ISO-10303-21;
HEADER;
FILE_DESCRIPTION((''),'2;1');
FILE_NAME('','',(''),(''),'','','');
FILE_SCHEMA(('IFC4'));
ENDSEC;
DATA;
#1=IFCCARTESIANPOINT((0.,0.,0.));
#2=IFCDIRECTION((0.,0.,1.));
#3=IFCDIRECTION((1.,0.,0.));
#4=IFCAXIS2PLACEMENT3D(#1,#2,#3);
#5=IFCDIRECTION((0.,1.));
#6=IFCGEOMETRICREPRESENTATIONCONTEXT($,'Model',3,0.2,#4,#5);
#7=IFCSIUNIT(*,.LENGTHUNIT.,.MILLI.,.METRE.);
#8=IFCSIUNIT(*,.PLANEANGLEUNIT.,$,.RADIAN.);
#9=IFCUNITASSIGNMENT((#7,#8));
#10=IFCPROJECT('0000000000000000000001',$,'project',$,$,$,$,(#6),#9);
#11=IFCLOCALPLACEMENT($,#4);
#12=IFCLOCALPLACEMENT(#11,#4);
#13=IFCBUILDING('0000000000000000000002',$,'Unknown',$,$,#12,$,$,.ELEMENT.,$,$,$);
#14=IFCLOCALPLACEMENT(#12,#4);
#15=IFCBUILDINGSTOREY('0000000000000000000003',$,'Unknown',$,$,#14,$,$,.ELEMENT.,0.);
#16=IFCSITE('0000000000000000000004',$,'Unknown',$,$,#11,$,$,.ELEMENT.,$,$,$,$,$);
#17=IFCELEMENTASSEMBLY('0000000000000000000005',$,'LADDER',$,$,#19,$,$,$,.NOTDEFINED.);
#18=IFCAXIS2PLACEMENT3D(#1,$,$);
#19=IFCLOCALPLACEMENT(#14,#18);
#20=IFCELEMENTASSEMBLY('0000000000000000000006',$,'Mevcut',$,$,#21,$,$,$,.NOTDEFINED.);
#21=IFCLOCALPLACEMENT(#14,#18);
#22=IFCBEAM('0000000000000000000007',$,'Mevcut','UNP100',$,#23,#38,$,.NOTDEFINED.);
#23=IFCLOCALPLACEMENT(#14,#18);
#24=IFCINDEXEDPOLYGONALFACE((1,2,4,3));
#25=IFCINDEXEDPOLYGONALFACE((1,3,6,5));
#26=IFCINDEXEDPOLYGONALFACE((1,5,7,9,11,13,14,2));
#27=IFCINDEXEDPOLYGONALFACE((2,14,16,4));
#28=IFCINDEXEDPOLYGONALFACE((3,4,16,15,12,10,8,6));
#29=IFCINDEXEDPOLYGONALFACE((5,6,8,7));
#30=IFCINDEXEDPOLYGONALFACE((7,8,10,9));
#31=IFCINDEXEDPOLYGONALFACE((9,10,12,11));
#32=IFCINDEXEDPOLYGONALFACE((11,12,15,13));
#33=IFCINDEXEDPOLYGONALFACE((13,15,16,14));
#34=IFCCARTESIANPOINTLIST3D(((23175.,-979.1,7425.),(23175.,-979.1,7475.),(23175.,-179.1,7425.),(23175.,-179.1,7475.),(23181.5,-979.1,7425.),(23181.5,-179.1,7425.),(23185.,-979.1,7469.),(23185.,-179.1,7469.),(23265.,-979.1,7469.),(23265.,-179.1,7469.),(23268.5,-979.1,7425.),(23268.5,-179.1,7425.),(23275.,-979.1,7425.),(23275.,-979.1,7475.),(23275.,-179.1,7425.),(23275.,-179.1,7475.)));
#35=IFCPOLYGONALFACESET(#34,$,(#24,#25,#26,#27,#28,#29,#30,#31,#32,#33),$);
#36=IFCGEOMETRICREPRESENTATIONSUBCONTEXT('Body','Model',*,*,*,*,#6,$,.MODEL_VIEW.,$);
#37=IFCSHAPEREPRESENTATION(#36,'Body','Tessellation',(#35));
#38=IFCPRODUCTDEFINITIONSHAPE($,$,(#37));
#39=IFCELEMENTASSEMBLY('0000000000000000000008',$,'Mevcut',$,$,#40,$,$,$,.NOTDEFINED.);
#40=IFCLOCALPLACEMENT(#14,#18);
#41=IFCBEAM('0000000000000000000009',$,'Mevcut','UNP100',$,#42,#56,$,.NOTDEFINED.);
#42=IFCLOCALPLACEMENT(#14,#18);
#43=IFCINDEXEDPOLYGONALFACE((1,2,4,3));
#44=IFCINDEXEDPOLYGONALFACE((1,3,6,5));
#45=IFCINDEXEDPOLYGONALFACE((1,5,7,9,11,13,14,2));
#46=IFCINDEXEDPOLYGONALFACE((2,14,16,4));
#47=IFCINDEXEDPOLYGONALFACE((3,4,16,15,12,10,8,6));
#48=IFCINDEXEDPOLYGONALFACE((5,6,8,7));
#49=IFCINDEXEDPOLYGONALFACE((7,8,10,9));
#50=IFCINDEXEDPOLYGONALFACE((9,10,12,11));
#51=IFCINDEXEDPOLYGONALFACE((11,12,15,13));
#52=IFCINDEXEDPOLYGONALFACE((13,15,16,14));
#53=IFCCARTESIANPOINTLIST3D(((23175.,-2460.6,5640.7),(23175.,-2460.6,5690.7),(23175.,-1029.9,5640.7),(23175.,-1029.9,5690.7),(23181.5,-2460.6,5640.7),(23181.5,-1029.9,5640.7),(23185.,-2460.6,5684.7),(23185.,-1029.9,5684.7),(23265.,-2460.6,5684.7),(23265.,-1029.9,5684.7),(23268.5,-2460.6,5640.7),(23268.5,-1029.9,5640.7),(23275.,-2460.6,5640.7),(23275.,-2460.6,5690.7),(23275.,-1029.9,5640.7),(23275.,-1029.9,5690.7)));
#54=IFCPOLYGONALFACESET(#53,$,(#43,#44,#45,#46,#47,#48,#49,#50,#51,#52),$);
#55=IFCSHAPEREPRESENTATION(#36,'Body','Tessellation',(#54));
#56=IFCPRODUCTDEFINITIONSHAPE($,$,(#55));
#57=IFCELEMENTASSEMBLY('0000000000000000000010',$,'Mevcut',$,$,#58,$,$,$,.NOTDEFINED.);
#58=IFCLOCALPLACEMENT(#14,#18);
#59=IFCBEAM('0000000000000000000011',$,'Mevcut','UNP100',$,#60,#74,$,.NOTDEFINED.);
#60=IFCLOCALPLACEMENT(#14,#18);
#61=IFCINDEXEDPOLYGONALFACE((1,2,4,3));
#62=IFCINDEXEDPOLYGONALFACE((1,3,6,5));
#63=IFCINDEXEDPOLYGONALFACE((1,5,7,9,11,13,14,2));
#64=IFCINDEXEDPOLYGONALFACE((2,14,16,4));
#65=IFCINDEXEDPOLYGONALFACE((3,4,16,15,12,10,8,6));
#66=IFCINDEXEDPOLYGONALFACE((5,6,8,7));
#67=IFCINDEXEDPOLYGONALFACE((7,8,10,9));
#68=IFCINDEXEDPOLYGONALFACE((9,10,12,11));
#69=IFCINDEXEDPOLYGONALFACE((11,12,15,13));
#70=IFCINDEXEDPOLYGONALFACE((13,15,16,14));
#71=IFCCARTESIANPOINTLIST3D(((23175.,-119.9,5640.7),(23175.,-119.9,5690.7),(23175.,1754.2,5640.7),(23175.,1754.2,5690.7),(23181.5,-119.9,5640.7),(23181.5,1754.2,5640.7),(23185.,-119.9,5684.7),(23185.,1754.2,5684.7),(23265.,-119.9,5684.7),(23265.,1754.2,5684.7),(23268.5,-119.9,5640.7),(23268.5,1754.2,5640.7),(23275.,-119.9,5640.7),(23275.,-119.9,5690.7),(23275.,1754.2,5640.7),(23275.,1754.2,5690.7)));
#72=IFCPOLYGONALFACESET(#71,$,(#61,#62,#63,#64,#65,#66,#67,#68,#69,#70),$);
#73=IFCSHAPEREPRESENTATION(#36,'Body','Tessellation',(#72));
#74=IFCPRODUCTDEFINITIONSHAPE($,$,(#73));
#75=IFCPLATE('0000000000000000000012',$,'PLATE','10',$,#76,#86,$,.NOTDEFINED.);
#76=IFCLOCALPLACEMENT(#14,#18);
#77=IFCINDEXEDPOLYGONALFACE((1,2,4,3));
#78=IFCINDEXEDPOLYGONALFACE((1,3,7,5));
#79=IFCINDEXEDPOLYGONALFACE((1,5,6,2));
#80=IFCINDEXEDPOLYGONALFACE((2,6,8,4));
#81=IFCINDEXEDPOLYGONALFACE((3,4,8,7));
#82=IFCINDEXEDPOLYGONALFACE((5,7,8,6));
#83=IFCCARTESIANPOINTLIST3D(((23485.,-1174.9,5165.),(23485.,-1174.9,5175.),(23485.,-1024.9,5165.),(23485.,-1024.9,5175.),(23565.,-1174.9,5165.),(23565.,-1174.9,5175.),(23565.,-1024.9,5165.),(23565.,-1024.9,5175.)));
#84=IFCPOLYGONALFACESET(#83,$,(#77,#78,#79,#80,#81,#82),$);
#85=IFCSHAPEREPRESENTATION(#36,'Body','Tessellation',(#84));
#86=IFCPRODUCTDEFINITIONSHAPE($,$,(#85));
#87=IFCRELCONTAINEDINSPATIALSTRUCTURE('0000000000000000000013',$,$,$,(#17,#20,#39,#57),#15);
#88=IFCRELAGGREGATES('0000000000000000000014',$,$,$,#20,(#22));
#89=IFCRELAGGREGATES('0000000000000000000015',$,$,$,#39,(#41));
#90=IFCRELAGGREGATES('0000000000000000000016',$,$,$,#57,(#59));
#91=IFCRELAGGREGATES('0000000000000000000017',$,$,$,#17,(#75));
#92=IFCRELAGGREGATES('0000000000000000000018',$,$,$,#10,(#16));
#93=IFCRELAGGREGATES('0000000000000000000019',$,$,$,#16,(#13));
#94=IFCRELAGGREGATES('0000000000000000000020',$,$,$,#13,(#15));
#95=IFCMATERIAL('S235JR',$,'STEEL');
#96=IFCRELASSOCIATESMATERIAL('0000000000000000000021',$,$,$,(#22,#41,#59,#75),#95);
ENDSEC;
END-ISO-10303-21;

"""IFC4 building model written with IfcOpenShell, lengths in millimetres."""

from ifc_helpers import new_model, si_unit, direction, frame, origin_with_axes, place, context, subcontext, project, spatial, line, indexed_curve, outline, extrude, material, element, aggregate, save


model = new_model("IFC4")

# Units and contexts
model_context = context("Model", 3, precision=0.2, world=origin_with_axes(), true_north=direction((0.0, 1.0)))
body_context = subcontext(model_context, "Body", "Model", "MODEL_VIEW")
ifc_project = project(units=[si_unit("LENGTHUNIT", "METRE", prefix="MILLI"), si_unit("PLANEANGLEUNIT", "RADIAN")], contexts=[model_context])

# Site, building, storey
site_placement = place(None, origin_with_axes())
site = spatial("IfcSite", under=ifc_project, at=site_placement, Name="Unknown", CompositionType="ELEMENT")
building_placement = place(site_placement, origin_with_axes())
building = spatial("IfcBuilding", under=site, at=building_placement, Name="Unknown", CompositionType="ELEMENT")
storey_placement = place(building_placement, origin_with_axes())
storey = spatial("IfcBuildingStorey", under=building, at=storey_placement, Name="Unknown", CompositionType="ELEMENT", Elevation=0.0)

# Element assembly
assembly_1_placement = place(storey_placement, frame((23525.0, -1699.9, 5175.0), z_axis=(0.0, 1.0, 0.0), x_axis=(0.0, 0.0, 1.0)))
assembly_1 = element("IfcElementAssembly", 1, at=assembly_1_placement, inside=storey, Name="LADDER", PredefinedType="NOTDEFINED")
ifc_material_1 = material(Name="S235JR", Category="STEEL")

# Element assemblies, beams
assembly_2_placement = place(storey_placement, frame((23225.0, -179.1, 7450.0), z_axis=(0.0, 0.0, -1.0), x_axis=(0.0, -1.0, 0.0)))
assembly_2 = element("IfcElementAssembly", 2, at=assembly_2_placement, inside=storey, Name="Mevcut", PredefinedType="NOTDEFINED")
beam_1_placement = place(assembly_2_placement, origin_with_axes())
beam_1 = element("IfcBeam", 3, at=beam_1_placement, material=ifc_material_1, Name="Mevcut", Description="UNP100", PredefinedType="NOTDEFINED", context=body_context, shape_type="SolidModel", body=[
    extrude(outline(indexed_curve([(-25.0, -50.0), (25.0, -50.0), (25.0, -43.5), (-19.0, -40.0), (-19.0, 40.0), (25.0, 43.5), (25.0, 50.0), (-25.0, 50.0)], segments=[line(1, 2, 3, 4, 5, 6, 7, 8, 1)])), frame((0.0, 0.0, 0.0), z_axis=(-1.0, 0.0, 0.0), x_axis=(0.0, 0.0, 1.0)), (0.0, 0.0, -1.0), 800.0),
])
aggregate(assembly_2, [beam_1])
assembly_3_placement = place(storey_placement, frame((23225.0, -1029.9, 5665.7), z_axis=(0.0, 0.0, -1.0), x_axis=(0.0, -1.0, 0.0)))
assembly_3 = element("IfcElementAssembly", 4, at=assembly_3_placement, inside=storey, Name="Mevcut", PredefinedType="NOTDEFINED")
beam_2_placement = place(assembly_3_placement, origin_with_axes())
beam_2 = element("IfcBeam", 5, at=beam_2_placement, material=ifc_material_1, Name="Mevcut", Description="UNP100", PredefinedType="NOTDEFINED", context=body_context, shape_type="SolidModel", body=[
    extrude(outline(indexed_curve([(-25.0, -50.0), (25.0, -50.0), (25.0, -43.5), (-19.0, -40.0), (-19.0, 40.0), (25.0, 43.5), (25.0, 50.0), (-25.0, 50.0)], segments=[line(1, 2, 3, 4, 5, 6, 7, 8, 1)])), frame((0.0, 0.0, 0.0), z_axis=(-1.0, 0.0, 0.0), x_axis=(0.0, 0.0, 1.0)), (0.0, 0.0, -1.0), 1430.7),
])
aggregate(assembly_3, [beam_2])
assembly_4_placement = place(storey_placement, frame((23225.0, 1754.2, 5665.7), z_axis=(0.0, 0.0, -1.0), x_axis=(0.0, -1.0, 0.0)))
assembly_4 = element("IfcElementAssembly", 6, at=assembly_4_placement, inside=storey, Name="Mevcut", PredefinedType="NOTDEFINED")
beam_3_placement = place(assembly_4_placement, origin_with_axes())
beam_3 = element("IfcBeam", 7, at=beam_3_placement, material=ifc_material_1, Name="Mevcut", Description="UNP100", PredefinedType="NOTDEFINED", context=body_context, shape_type="SolidModel", body=[
    extrude(outline(indexed_curve([(-25.0, -50.0), (25.0, -50.0), (25.0, -43.5), (-19.0, -40.0), (-19.0, 40.0), (25.0, 43.5), (25.0, 50.0), (-25.0, 50.0)], segments=[line(1, 2, 3, 4, 5, 6, 7, 8, 1)])), frame((0.0, 0.0, 0.0), z_axis=(-1.0, 0.0, 0.0), x_axis=(0.0, 0.0, 1.0)), (0.0, 0.0, -1.0), 1874.2),
])
aggregate(assembly_4, [beam_3])

# Plate
plate_1_placement = place(assembly_1_placement, frame((-5.0, -40.0, 675.0), z_axis=(-1.0, 0.0, 0.0), x_axis=(0.0, 1.0, 0.0)))
plate_1 = element("IfcPlate", 8, at=plate_1_placement, material=ifc_material_1, Name="PLATE", Description="10", PredefinedType="NOTDEFINED", context=body_context, shape_type="SolidModel", body=[
    extrude(outline(indexed_curve([(0.0, 0.0), (80.0, 0.0), (80.0, 150.0), (0.0, 150.0)], segments=[line(1, 2, 3, 4, 1)])), frame((0.0, 0.0, 5.0), z_axis=(0.0, 0.0, 1.0), x_axis=(1.0, 0.0, 0.0)), (0.0, 0.0, -1.0), 10.0),
])
aggregate(assembly_1, [plate_1])

save(model, "model.ifc")
